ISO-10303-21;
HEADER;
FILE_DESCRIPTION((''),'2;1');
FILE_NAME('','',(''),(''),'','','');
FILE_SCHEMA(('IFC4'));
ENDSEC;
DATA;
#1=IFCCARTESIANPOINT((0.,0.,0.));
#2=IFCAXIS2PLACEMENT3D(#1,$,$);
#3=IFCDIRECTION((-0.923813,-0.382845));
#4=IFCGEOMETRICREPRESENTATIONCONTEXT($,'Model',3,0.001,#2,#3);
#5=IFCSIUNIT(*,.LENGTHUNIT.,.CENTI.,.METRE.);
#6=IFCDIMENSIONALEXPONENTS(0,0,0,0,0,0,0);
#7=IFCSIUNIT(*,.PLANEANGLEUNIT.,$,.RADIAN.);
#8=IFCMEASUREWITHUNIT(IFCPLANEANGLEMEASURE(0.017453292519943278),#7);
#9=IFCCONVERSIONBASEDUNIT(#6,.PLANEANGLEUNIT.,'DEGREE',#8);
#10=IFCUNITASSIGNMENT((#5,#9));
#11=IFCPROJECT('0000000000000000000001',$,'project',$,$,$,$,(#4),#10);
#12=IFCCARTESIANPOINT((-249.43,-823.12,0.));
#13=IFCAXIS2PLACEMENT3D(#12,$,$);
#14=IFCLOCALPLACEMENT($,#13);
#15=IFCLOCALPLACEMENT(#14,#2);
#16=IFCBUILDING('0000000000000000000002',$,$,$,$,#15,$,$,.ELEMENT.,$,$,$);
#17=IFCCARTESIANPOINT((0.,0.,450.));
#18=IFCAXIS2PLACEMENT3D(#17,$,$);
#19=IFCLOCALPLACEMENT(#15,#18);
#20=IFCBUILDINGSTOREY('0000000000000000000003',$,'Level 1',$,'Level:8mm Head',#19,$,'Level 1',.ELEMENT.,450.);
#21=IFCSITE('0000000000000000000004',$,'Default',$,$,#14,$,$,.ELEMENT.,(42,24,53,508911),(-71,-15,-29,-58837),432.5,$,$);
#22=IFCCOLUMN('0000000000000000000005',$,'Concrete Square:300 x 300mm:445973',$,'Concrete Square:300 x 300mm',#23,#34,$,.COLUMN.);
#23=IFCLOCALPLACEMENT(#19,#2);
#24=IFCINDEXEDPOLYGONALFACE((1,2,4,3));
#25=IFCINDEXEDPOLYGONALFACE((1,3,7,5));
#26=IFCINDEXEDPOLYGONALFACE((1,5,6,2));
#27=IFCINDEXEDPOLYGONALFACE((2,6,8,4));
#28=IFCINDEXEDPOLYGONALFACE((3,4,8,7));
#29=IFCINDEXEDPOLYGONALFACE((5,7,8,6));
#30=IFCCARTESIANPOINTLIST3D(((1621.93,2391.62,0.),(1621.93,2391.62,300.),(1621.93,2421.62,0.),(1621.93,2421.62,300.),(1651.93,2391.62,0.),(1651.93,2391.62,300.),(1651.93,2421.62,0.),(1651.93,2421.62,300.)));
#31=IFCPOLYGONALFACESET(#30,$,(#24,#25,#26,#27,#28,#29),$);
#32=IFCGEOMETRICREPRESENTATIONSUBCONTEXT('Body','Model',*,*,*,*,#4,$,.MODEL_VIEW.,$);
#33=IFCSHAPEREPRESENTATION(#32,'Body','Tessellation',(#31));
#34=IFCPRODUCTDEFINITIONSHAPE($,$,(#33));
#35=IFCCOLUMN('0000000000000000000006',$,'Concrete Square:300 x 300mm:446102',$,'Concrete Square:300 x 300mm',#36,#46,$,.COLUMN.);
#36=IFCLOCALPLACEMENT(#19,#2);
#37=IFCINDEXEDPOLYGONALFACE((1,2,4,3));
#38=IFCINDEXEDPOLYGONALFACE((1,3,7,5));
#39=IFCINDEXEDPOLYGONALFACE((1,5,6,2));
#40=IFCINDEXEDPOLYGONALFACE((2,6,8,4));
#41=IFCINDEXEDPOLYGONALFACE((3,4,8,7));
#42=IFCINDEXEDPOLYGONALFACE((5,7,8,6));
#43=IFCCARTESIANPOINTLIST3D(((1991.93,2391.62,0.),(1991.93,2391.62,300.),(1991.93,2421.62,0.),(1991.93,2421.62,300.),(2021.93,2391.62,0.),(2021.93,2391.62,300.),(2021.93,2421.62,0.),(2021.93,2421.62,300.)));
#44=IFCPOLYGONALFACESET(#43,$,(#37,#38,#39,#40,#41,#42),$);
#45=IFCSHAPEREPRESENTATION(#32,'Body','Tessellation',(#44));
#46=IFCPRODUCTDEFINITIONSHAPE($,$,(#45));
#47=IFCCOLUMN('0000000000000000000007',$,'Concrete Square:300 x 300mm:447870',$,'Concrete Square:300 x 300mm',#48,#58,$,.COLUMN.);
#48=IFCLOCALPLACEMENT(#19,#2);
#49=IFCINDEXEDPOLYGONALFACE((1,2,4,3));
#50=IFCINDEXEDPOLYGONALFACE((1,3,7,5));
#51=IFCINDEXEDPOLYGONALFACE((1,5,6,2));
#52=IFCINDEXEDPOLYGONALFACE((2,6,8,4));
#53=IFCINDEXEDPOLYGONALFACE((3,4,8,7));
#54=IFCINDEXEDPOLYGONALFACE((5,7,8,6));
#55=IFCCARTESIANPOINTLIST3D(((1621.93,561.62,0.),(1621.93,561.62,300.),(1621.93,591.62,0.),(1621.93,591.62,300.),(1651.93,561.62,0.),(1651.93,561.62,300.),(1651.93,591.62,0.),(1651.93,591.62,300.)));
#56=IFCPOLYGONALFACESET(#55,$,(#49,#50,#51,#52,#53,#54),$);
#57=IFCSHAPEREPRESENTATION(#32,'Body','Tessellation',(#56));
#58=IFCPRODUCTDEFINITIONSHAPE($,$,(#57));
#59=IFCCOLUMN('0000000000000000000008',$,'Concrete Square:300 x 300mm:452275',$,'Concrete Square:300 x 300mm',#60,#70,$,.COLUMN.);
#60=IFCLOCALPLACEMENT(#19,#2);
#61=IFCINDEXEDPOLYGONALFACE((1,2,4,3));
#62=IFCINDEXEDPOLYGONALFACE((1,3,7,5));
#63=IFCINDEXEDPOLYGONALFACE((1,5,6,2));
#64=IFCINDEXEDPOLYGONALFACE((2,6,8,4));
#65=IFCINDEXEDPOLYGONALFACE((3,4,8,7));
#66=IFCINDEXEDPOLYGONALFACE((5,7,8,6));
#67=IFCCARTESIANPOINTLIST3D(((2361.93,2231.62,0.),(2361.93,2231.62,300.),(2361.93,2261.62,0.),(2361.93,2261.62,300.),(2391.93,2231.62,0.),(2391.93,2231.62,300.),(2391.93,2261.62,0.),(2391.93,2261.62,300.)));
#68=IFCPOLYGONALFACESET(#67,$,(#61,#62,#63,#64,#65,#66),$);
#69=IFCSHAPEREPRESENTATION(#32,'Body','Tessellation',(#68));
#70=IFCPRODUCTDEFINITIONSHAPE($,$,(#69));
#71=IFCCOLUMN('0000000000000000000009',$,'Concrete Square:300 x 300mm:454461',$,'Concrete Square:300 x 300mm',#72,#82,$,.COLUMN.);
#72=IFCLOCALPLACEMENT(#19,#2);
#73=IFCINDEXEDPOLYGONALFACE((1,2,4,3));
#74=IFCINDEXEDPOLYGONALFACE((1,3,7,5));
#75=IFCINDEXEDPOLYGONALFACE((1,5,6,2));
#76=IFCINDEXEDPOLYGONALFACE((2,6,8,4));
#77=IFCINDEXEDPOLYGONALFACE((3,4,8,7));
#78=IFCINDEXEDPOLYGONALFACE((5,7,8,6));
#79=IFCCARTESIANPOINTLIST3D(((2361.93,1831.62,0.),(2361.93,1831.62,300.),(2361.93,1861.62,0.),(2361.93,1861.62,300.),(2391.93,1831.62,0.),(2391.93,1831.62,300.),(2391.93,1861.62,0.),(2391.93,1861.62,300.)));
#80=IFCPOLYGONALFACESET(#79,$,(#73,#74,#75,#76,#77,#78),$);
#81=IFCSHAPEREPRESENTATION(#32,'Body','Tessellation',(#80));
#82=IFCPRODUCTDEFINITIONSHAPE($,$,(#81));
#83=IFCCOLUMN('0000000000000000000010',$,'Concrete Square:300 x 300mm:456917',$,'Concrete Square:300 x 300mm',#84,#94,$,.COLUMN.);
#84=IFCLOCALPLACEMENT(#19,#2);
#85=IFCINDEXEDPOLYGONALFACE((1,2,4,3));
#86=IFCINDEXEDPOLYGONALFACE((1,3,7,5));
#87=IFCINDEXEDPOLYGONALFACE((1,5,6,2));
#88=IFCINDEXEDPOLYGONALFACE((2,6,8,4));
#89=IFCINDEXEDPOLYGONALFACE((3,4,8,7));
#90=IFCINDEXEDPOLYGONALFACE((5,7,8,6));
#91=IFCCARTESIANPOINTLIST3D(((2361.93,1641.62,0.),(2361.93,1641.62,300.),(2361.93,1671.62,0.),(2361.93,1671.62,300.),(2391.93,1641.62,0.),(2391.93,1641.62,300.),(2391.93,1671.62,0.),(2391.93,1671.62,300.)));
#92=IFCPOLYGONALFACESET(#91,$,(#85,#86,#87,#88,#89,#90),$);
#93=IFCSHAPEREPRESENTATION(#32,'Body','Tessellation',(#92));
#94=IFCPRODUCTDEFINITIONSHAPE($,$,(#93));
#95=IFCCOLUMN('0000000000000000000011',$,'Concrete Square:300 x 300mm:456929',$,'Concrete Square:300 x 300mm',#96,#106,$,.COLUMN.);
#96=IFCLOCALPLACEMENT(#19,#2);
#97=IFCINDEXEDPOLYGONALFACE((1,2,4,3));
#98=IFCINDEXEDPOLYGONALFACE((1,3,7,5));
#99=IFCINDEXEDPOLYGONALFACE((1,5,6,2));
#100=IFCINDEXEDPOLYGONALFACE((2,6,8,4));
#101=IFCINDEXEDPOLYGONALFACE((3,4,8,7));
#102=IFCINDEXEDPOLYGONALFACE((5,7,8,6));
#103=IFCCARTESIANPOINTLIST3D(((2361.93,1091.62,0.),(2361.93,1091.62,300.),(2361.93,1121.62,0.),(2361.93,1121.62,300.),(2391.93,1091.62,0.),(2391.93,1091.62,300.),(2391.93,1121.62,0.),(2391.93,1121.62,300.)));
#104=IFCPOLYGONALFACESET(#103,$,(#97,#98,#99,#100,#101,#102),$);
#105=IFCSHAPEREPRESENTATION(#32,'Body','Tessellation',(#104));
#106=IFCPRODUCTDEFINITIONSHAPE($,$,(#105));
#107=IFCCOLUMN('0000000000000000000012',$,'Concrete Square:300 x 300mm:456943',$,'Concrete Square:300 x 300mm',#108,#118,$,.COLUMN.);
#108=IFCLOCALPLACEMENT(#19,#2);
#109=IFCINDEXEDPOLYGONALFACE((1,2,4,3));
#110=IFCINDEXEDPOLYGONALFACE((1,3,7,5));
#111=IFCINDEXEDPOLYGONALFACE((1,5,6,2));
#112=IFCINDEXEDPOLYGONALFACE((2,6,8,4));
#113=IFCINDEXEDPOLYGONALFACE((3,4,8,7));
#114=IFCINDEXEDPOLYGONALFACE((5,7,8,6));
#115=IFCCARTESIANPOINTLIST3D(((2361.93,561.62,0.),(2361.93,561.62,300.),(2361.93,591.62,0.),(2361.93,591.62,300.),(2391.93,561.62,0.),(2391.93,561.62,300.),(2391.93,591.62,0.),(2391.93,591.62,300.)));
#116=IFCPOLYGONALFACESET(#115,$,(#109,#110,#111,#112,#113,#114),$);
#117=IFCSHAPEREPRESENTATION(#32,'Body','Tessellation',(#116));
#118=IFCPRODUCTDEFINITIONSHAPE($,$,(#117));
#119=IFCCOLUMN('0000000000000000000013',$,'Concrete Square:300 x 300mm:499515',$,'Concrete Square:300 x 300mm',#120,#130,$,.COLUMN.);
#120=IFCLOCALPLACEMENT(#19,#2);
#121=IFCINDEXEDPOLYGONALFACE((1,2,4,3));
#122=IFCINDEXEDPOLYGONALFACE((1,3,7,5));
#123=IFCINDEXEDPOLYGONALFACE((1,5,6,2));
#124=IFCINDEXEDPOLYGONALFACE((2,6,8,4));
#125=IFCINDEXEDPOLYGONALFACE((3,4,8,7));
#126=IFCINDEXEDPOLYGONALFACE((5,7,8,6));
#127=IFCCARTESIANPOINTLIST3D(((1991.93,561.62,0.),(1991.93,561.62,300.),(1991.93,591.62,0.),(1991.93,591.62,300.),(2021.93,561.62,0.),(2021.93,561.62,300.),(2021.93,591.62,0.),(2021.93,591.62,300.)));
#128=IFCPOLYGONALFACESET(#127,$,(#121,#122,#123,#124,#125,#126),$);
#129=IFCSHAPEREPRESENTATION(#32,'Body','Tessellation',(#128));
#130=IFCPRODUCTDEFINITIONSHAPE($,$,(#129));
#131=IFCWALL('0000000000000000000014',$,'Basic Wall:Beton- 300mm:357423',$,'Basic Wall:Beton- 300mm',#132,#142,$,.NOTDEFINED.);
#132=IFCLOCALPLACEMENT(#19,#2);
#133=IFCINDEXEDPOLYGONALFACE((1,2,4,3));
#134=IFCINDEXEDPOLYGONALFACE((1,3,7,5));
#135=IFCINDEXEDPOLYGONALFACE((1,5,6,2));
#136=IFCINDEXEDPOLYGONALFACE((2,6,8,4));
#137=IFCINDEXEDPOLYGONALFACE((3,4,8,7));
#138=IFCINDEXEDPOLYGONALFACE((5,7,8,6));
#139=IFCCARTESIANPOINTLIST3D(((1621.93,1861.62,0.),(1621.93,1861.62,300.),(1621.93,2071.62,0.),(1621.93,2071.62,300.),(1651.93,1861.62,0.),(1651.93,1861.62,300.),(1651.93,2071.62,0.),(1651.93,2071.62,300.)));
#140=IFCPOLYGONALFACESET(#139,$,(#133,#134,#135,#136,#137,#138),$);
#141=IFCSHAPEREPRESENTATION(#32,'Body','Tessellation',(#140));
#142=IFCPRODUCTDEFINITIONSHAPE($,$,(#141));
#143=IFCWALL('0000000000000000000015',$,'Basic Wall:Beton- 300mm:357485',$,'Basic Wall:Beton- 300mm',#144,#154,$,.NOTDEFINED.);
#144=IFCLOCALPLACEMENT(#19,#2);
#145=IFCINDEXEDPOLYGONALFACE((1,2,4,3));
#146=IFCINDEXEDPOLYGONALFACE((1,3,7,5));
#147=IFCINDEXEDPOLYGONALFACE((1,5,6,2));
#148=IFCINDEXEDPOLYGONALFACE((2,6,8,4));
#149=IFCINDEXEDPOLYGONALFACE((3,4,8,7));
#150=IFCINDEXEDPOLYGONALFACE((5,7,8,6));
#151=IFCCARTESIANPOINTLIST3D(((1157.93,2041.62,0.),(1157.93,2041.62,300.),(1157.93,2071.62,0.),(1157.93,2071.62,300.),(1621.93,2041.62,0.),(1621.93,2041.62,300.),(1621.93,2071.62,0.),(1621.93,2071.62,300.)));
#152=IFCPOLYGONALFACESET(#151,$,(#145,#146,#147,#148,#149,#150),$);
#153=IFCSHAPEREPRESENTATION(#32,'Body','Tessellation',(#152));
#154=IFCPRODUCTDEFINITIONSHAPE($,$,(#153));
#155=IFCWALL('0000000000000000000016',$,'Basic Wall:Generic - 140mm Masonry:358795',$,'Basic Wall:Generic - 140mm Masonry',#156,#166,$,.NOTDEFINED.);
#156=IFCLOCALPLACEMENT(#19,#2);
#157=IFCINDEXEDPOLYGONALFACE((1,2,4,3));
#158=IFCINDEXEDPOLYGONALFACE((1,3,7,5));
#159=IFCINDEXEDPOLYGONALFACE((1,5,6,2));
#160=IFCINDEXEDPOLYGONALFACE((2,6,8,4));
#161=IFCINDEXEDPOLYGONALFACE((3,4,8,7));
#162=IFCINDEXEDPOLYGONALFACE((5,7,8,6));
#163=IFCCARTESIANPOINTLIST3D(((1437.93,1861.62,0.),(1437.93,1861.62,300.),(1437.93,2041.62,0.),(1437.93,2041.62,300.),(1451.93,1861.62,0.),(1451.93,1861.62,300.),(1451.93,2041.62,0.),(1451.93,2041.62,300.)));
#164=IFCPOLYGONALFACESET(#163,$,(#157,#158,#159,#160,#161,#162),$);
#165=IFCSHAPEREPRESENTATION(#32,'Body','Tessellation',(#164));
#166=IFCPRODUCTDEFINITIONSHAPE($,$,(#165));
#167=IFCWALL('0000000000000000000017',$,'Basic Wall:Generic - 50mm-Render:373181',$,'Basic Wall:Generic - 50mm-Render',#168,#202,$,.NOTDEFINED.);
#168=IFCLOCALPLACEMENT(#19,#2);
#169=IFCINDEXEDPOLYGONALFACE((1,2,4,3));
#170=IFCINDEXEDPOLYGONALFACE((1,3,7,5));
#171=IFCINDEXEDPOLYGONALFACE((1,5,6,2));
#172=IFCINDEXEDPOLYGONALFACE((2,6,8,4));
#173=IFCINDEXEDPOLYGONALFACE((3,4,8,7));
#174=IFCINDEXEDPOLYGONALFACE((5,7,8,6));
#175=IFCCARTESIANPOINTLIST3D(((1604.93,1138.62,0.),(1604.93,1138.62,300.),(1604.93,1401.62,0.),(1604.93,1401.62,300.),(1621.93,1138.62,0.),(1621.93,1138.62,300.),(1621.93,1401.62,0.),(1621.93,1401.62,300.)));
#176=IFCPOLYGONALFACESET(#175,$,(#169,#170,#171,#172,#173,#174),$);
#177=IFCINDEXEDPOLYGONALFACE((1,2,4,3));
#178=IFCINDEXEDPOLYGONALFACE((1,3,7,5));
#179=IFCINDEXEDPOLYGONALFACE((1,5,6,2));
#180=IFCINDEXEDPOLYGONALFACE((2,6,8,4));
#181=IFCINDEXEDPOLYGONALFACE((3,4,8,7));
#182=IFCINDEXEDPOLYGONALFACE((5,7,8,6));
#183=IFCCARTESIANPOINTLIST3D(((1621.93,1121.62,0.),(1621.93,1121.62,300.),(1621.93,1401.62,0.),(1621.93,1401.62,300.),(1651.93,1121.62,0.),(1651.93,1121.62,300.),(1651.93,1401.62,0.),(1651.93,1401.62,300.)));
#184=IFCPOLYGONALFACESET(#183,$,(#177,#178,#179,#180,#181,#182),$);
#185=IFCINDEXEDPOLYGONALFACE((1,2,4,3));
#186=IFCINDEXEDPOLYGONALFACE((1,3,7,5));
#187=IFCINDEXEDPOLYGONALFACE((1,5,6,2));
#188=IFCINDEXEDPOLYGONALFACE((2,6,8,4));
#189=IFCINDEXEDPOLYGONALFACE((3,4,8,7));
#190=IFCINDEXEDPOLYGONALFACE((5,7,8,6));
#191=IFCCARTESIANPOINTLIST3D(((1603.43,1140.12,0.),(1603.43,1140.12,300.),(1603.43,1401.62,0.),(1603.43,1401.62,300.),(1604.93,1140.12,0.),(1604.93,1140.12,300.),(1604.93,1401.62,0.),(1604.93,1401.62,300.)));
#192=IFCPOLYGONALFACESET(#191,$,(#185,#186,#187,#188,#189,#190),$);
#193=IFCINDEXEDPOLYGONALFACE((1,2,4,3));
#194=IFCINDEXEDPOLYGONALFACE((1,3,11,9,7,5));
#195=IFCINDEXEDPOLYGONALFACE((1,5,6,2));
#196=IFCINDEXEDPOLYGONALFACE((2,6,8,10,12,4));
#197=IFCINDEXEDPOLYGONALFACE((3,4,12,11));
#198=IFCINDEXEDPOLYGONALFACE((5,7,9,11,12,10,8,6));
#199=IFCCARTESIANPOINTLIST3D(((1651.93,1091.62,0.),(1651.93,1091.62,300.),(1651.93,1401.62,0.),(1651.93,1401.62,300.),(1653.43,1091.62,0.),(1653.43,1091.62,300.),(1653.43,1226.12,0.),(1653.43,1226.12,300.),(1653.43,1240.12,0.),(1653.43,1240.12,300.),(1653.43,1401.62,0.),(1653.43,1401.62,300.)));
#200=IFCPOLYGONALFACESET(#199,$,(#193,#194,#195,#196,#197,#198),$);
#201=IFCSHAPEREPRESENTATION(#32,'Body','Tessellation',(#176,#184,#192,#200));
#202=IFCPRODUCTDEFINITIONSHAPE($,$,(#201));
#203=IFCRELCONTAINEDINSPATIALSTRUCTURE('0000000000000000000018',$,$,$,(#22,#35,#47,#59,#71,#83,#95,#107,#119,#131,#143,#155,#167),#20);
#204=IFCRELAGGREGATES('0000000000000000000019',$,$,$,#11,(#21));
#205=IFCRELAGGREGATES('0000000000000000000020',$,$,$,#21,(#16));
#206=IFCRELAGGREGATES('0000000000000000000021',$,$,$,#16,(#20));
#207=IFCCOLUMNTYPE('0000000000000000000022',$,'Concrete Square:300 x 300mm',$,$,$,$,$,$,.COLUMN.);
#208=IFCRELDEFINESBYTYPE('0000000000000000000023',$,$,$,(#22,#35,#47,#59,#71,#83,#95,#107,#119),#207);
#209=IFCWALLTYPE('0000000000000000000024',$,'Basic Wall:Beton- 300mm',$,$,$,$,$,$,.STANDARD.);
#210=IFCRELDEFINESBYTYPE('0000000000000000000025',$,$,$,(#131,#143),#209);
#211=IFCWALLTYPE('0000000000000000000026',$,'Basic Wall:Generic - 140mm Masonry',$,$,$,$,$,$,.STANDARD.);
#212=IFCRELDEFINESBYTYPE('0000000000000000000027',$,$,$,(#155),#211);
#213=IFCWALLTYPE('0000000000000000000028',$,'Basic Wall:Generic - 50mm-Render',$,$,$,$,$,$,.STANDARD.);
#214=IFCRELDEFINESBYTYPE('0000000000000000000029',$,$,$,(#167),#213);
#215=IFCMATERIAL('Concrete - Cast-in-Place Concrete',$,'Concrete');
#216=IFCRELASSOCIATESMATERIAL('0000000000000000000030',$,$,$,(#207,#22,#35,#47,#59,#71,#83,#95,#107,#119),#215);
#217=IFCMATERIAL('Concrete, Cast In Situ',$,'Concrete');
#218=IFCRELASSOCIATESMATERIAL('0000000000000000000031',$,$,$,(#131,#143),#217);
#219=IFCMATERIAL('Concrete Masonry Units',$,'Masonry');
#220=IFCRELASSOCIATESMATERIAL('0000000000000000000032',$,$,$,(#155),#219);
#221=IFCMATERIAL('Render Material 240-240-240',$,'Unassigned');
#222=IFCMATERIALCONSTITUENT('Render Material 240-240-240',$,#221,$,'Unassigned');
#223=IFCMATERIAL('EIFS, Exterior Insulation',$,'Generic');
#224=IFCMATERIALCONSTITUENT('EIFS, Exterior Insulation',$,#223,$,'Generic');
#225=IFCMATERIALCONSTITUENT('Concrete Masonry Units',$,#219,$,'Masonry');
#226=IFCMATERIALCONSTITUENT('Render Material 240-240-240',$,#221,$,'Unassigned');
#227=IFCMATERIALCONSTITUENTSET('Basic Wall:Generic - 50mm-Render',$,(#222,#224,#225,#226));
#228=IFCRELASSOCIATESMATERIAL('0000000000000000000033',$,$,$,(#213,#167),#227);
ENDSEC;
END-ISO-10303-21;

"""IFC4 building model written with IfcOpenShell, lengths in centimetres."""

from ifc_helpers import new_model, entity, si_unit, converted_unit, direction, frame, origin, place, context, subcontext, project, spatial, indexed_curve, outline, extrude, source, transform, mapped, material, constituent, constituent_set, type_object, type_shapes, element, save


model = new_model("IFC4")

# Units and contexts
model_context = context("Model", 3, precision=0.001, world=origin(), true_north=direction((-0.923813, -0.382845)))
body_context = subcontext(model_context, "Body", "Model", "MODEL_VIEW")
ifc_project = project(units=[si_unit("LENGTHUNIT", "METRE", prefix="CENTI"), converted_unit("PLANEANGLEUNIT", "DEGREE", entity("IfcPlaneAngleMeasure", 0.017453292519943278), si_unit("PLANEANGLEUNIT", "RADIAN"), dimensions=[0, 0, 0, 0, 0, 0, 0])], contexts=[model_context])

# Site, building, storey
site_placement = place(None, frame((-249.43, -823.12, 0.0)))
site = spatial("IfcSite", under=ifc_project, at=site_placement, Name="Default", CompositionType="ELEMENT", RefLatitude=(42, 24, 53, 508911), RefLongitude=(-71, -15, -29, -58837), RefElevation=432.5)
building_placement = place(site_placement, origin())
building = spatial("IfcBuilding", under=site, at=building_placement, CompositionType="ELEMENT")
storey_placement = place(building_placement, frame((0.0, 0.0, 450.0)))
storey = spatial("IfcBuildingStorey", under=building, at=storey_placement, Name="Level 1", ObjectType="Level:8mm Head", LongName="Level 1", CompositionType="ELEMENT", Elevation=450.0)

# Columns
ifc_material_1 = material(Name="Concrete - Cast-in-Place Concrete", Category="Concrete")
column_type = type_object("IfcColumnType", Name="Concrete Square:300 x 300mm", PredefinedType="COLUMN", material=ifc_material_1)
shared_shape_1 = source(origin(), body_context, "Body", "SweptSolid", [
    extrude(outline(indexed_curve([(-15.0, -15.0), (15.0, -15.0), (15.0, 15.0), (-15.0, 15.0), (-15.0, -15.0)], self_intersect=False)), frame((0.0, 0.0, 450.0), z_axis=(0.0, 0.0, 1.0), x_axis=(-1.0, 0.0, 0.0)), (0.0, 0.0, 1.0), 300.0),
])
type_shapes(column_type, [shared_shape_1])
for number, where, name in (
    (1, (1636.93, 2406.62, -450.0), "Concrete Square:300 x 300mm:445973"),
    (2, (2006.93, 2406.62, -450.0), "Concrete Square:300 x 300mm:446102"),
    (3, (1636.93, 576.62, -450.0), "Concrete Square:300 x 300mm:447870"),
    (4, (2376.93, 2246.62, -450.0), "Concrete Square:300 x 300mm:452275"),
    (5, (2376.93, 1846.62, -450.0), "Concrete Square:300 x 300mm:454461"),
    (6, (2376.93, 1656.62, -450.0), "Concrete Square:300 x 300mm:456917"),
    (7, (2376.93, 1106.62, -450.0), "Concrete Square:300 x 300mm:456929"),
    (8, (2376.93, 576.62, -450.0), "Concrete Square:300 x 300mm:456943"),
    (9, (2006.93, 576.62, -450.0), "Concrete Square:300 x 300mm:499515"),
):
    element("IfcColumn", number, at=place(storey_placement, frame(where)), inside=storey, type_object=column_type, material=ifc_material_1, Name=name, ObjectType="Concrete Square:300 x 300mm", PredefinedType="COLUMN", context=body_context, shape_type="MappedRepresentation", body=[
        mapped(shared_shape_1, transform((0.0, 0.0, 0.0), scale=1.0)),
    ])

# Walls
ifc_material_2 = material(Name="Concrete, Cast In Situ", Category="Concrete")
wall_type_1 = type_object("IfcWallType", Name="Basic Wall:Beton- 300mm", PredefinedType="STANDARD")
wall_1_placement = place(storey_placement, frame((1636.93, 1861.62, 0.0), z_axis=(0.0, 0.0, 1.0), x_axis=(0.0, 1.0, 0.0)))
element("IfcWall", 10, at=wall_1_placement, inside=storey, type_object=wall_type_1, material=ifc_material_2, Name="Basic Wall:Beton- 300mm:357423", ObjectType="Basic Wall:Beton- 300mm", PredefinedType="NOTDEFINED", context=body_context, shape_type="SweptSolid", body=[
    extrude(outline(indexed_curve([(210.0, 15.0), (0.0, 15.0), (0.0, -15.0), (210.0, -15.0), (210.0, 15.0)], self_intersect=False)), origin(), (0.0, 0.0, 1.0), 300.0),
])
wall_2_placement = place(storey_placement, frame((1621.93, 2056.62, 0.0), z_axis=(0.0, 0.0, 1.0), x_axis=(-1.0, 0.0, 0.0)))
element("IfcWall", 11, at=wall_2_placement, inside=storey, type_object=wall_type_1, material=ifc_material_2, Name="Basic Wall:Beton- 300mm:357485", ObjectType="Basic Wall:Beton- 300mm", PredefinedType="NOTDEFINED", context=body_context, shape_type="SweptSolid", body=[
    extrude(outline(indexed_curve([(464.0, 15.0), (0.0, 15.0), (0.0, -15.0), (464.0, -15.0), (464.0, 15.0)], self_intersect=False)), origin(), (0.0, 0.0, 1.0), 300.0),
])
ifc_material_3 = material(Name="Concrete Masonry Units", Category="Masonry")
wall_type_2 = type_object("IfcWallType", Name="Basic Wall:Generic - 140mm Masonry", PredefinedType="STANDARD")
wall_3_placement = place(storey_placement, frame((1444.93, 2041.62, 0.0), z_axis=(0.0, 0.0, 1.0), x_axis=(0.0, -1.0, 0.0)))
element("IfcWall", 12, at=wall_3_placement, inside=storey, type_object=wall_type_2, material=ifc_material_3, Name="Basic Wall:Generic - 140mm Masonry:358795", ObjectType="Basic Wall:Generic - 140mm Masonry", PredefinedType="NOTDEFINED", context=body_context, shape_type="SweptSolid", body=[
    extrude(outline(indexed_curve([(180.0, 7.0), (0.0, 7.0), (0.0, -7.0), (180.0, -7.0), (180.0, 7.0)], self_intersect=False)), origin(), (0.0, 0.0, 1.0), 300.0),
])
ifc_material_4 = material(Name="Render Material 240-240-240", Category="Unassigned")
ifc_constituent_1 = constituent(ifc_material_4, Name="Render Material 240-240-240", Category="Unassigned")
ifc_material_5 = material(Name="EIFS, Exterior Insulation", Category="Generic")
ifc_constituent_2 = constituent(ifc_material_5, Name="EIFS, Exterior Insulation", Category="Generic")
ifc_constituent_3 = constituent(ifc_material_3, Name="Concrete Masonry Units", Category="Masonry")
ifc_constituent_4 = constituent(ifc_material_4, Name="Render Material 240-240-240", Category="Unassigned")
ifc_constituent_set_1 = constituent_set(constituents=[ifc_constituent_1, ifc_constituent_2, ifc_constituent_3, ifc_constituent_4], Name="Basic Wall:Generic - 50mm-Render")
wall_type_3 = type_object("IfcWallType", Name="Basic Wall:Generic - 50mm-Render", PredefinedType="STANDARD", material=ifc_constituent_set_1)
wall_4_placement = place(storey_placement, frame((1628.43, 1401.62, 0.0), z_axis=(0.0, 0.0, 1.0), x_axis=(0.0, -1.0, 0.0)))
element("IfcWall", 13, at=wall_4_placement, inside=storey, type_object=wall_type_3, material=ifc_constituent_set_1, Name="Basic Wall:Generic - 50mm-Render:373181", ObjectType="Basic Wall:Generic - 50mm-Render", PredefinedType="NOTDEFINED", context=body_context, shape_type="SweptSolid", body=[
    extrude(outline(indexed_curve([(-8.5, -131.5), (8.5, -131.5), (8.5, 131.5), (-8.5, 131.5), (-8.5, -131.5)], self_intersect=False)), frame((131.5, -15.0, 0.0), z_axis=(0.0, 0.0, 1.0), x_axis=(0.0, 1.0, 0.0)), (0.0, 0.0, 1.0), 300.0),
    extrude(outline(indexed_curve([(-15.0, -140.0), (15.0, -140.0), (15.0, 140.0), (-15.0, 140.0), (-15.0, -140.0)], self_intersect=False)), frame((140.0, 8.5, 0.0), z_axis=(0.0, 0.0, 1.0), x_axis=(0.0, -1.0, 0.0)), (0.0, 0.0, 1.0), 300.0),
    extrude(outline(indexed_curve([(-0.75, -130.75), (0.75, -130.75), (0.75, 130.75), (-0.75, 130.75), (-0.75, -130.75)], self_intersect=False)), frame((130.75, -24.25, 0.0), z_axis=(0.0, 0.0, 1.0), x_axis=(0.0, 1.0, 0.0)), (0.0, 0.0, 1.0), 300.0),
    extrude(outline(indexed_curve([(-1.0, -150.5), (0.5, -150.5), (0.5, -16.0), (0.5, -2.0), (0.5, 159.5), (-1.0, 159.5), (-1.0, -150.5)], self_intersect=False)), frame((159.5, 24.5, 0.0), z_axis=(0.0, 0.0, 1.0), x_axis=(0.0, 1.0, 0.0)), (0.0, 0.0, 1.0), 300.0),
])

save(model, "model.ifc")
